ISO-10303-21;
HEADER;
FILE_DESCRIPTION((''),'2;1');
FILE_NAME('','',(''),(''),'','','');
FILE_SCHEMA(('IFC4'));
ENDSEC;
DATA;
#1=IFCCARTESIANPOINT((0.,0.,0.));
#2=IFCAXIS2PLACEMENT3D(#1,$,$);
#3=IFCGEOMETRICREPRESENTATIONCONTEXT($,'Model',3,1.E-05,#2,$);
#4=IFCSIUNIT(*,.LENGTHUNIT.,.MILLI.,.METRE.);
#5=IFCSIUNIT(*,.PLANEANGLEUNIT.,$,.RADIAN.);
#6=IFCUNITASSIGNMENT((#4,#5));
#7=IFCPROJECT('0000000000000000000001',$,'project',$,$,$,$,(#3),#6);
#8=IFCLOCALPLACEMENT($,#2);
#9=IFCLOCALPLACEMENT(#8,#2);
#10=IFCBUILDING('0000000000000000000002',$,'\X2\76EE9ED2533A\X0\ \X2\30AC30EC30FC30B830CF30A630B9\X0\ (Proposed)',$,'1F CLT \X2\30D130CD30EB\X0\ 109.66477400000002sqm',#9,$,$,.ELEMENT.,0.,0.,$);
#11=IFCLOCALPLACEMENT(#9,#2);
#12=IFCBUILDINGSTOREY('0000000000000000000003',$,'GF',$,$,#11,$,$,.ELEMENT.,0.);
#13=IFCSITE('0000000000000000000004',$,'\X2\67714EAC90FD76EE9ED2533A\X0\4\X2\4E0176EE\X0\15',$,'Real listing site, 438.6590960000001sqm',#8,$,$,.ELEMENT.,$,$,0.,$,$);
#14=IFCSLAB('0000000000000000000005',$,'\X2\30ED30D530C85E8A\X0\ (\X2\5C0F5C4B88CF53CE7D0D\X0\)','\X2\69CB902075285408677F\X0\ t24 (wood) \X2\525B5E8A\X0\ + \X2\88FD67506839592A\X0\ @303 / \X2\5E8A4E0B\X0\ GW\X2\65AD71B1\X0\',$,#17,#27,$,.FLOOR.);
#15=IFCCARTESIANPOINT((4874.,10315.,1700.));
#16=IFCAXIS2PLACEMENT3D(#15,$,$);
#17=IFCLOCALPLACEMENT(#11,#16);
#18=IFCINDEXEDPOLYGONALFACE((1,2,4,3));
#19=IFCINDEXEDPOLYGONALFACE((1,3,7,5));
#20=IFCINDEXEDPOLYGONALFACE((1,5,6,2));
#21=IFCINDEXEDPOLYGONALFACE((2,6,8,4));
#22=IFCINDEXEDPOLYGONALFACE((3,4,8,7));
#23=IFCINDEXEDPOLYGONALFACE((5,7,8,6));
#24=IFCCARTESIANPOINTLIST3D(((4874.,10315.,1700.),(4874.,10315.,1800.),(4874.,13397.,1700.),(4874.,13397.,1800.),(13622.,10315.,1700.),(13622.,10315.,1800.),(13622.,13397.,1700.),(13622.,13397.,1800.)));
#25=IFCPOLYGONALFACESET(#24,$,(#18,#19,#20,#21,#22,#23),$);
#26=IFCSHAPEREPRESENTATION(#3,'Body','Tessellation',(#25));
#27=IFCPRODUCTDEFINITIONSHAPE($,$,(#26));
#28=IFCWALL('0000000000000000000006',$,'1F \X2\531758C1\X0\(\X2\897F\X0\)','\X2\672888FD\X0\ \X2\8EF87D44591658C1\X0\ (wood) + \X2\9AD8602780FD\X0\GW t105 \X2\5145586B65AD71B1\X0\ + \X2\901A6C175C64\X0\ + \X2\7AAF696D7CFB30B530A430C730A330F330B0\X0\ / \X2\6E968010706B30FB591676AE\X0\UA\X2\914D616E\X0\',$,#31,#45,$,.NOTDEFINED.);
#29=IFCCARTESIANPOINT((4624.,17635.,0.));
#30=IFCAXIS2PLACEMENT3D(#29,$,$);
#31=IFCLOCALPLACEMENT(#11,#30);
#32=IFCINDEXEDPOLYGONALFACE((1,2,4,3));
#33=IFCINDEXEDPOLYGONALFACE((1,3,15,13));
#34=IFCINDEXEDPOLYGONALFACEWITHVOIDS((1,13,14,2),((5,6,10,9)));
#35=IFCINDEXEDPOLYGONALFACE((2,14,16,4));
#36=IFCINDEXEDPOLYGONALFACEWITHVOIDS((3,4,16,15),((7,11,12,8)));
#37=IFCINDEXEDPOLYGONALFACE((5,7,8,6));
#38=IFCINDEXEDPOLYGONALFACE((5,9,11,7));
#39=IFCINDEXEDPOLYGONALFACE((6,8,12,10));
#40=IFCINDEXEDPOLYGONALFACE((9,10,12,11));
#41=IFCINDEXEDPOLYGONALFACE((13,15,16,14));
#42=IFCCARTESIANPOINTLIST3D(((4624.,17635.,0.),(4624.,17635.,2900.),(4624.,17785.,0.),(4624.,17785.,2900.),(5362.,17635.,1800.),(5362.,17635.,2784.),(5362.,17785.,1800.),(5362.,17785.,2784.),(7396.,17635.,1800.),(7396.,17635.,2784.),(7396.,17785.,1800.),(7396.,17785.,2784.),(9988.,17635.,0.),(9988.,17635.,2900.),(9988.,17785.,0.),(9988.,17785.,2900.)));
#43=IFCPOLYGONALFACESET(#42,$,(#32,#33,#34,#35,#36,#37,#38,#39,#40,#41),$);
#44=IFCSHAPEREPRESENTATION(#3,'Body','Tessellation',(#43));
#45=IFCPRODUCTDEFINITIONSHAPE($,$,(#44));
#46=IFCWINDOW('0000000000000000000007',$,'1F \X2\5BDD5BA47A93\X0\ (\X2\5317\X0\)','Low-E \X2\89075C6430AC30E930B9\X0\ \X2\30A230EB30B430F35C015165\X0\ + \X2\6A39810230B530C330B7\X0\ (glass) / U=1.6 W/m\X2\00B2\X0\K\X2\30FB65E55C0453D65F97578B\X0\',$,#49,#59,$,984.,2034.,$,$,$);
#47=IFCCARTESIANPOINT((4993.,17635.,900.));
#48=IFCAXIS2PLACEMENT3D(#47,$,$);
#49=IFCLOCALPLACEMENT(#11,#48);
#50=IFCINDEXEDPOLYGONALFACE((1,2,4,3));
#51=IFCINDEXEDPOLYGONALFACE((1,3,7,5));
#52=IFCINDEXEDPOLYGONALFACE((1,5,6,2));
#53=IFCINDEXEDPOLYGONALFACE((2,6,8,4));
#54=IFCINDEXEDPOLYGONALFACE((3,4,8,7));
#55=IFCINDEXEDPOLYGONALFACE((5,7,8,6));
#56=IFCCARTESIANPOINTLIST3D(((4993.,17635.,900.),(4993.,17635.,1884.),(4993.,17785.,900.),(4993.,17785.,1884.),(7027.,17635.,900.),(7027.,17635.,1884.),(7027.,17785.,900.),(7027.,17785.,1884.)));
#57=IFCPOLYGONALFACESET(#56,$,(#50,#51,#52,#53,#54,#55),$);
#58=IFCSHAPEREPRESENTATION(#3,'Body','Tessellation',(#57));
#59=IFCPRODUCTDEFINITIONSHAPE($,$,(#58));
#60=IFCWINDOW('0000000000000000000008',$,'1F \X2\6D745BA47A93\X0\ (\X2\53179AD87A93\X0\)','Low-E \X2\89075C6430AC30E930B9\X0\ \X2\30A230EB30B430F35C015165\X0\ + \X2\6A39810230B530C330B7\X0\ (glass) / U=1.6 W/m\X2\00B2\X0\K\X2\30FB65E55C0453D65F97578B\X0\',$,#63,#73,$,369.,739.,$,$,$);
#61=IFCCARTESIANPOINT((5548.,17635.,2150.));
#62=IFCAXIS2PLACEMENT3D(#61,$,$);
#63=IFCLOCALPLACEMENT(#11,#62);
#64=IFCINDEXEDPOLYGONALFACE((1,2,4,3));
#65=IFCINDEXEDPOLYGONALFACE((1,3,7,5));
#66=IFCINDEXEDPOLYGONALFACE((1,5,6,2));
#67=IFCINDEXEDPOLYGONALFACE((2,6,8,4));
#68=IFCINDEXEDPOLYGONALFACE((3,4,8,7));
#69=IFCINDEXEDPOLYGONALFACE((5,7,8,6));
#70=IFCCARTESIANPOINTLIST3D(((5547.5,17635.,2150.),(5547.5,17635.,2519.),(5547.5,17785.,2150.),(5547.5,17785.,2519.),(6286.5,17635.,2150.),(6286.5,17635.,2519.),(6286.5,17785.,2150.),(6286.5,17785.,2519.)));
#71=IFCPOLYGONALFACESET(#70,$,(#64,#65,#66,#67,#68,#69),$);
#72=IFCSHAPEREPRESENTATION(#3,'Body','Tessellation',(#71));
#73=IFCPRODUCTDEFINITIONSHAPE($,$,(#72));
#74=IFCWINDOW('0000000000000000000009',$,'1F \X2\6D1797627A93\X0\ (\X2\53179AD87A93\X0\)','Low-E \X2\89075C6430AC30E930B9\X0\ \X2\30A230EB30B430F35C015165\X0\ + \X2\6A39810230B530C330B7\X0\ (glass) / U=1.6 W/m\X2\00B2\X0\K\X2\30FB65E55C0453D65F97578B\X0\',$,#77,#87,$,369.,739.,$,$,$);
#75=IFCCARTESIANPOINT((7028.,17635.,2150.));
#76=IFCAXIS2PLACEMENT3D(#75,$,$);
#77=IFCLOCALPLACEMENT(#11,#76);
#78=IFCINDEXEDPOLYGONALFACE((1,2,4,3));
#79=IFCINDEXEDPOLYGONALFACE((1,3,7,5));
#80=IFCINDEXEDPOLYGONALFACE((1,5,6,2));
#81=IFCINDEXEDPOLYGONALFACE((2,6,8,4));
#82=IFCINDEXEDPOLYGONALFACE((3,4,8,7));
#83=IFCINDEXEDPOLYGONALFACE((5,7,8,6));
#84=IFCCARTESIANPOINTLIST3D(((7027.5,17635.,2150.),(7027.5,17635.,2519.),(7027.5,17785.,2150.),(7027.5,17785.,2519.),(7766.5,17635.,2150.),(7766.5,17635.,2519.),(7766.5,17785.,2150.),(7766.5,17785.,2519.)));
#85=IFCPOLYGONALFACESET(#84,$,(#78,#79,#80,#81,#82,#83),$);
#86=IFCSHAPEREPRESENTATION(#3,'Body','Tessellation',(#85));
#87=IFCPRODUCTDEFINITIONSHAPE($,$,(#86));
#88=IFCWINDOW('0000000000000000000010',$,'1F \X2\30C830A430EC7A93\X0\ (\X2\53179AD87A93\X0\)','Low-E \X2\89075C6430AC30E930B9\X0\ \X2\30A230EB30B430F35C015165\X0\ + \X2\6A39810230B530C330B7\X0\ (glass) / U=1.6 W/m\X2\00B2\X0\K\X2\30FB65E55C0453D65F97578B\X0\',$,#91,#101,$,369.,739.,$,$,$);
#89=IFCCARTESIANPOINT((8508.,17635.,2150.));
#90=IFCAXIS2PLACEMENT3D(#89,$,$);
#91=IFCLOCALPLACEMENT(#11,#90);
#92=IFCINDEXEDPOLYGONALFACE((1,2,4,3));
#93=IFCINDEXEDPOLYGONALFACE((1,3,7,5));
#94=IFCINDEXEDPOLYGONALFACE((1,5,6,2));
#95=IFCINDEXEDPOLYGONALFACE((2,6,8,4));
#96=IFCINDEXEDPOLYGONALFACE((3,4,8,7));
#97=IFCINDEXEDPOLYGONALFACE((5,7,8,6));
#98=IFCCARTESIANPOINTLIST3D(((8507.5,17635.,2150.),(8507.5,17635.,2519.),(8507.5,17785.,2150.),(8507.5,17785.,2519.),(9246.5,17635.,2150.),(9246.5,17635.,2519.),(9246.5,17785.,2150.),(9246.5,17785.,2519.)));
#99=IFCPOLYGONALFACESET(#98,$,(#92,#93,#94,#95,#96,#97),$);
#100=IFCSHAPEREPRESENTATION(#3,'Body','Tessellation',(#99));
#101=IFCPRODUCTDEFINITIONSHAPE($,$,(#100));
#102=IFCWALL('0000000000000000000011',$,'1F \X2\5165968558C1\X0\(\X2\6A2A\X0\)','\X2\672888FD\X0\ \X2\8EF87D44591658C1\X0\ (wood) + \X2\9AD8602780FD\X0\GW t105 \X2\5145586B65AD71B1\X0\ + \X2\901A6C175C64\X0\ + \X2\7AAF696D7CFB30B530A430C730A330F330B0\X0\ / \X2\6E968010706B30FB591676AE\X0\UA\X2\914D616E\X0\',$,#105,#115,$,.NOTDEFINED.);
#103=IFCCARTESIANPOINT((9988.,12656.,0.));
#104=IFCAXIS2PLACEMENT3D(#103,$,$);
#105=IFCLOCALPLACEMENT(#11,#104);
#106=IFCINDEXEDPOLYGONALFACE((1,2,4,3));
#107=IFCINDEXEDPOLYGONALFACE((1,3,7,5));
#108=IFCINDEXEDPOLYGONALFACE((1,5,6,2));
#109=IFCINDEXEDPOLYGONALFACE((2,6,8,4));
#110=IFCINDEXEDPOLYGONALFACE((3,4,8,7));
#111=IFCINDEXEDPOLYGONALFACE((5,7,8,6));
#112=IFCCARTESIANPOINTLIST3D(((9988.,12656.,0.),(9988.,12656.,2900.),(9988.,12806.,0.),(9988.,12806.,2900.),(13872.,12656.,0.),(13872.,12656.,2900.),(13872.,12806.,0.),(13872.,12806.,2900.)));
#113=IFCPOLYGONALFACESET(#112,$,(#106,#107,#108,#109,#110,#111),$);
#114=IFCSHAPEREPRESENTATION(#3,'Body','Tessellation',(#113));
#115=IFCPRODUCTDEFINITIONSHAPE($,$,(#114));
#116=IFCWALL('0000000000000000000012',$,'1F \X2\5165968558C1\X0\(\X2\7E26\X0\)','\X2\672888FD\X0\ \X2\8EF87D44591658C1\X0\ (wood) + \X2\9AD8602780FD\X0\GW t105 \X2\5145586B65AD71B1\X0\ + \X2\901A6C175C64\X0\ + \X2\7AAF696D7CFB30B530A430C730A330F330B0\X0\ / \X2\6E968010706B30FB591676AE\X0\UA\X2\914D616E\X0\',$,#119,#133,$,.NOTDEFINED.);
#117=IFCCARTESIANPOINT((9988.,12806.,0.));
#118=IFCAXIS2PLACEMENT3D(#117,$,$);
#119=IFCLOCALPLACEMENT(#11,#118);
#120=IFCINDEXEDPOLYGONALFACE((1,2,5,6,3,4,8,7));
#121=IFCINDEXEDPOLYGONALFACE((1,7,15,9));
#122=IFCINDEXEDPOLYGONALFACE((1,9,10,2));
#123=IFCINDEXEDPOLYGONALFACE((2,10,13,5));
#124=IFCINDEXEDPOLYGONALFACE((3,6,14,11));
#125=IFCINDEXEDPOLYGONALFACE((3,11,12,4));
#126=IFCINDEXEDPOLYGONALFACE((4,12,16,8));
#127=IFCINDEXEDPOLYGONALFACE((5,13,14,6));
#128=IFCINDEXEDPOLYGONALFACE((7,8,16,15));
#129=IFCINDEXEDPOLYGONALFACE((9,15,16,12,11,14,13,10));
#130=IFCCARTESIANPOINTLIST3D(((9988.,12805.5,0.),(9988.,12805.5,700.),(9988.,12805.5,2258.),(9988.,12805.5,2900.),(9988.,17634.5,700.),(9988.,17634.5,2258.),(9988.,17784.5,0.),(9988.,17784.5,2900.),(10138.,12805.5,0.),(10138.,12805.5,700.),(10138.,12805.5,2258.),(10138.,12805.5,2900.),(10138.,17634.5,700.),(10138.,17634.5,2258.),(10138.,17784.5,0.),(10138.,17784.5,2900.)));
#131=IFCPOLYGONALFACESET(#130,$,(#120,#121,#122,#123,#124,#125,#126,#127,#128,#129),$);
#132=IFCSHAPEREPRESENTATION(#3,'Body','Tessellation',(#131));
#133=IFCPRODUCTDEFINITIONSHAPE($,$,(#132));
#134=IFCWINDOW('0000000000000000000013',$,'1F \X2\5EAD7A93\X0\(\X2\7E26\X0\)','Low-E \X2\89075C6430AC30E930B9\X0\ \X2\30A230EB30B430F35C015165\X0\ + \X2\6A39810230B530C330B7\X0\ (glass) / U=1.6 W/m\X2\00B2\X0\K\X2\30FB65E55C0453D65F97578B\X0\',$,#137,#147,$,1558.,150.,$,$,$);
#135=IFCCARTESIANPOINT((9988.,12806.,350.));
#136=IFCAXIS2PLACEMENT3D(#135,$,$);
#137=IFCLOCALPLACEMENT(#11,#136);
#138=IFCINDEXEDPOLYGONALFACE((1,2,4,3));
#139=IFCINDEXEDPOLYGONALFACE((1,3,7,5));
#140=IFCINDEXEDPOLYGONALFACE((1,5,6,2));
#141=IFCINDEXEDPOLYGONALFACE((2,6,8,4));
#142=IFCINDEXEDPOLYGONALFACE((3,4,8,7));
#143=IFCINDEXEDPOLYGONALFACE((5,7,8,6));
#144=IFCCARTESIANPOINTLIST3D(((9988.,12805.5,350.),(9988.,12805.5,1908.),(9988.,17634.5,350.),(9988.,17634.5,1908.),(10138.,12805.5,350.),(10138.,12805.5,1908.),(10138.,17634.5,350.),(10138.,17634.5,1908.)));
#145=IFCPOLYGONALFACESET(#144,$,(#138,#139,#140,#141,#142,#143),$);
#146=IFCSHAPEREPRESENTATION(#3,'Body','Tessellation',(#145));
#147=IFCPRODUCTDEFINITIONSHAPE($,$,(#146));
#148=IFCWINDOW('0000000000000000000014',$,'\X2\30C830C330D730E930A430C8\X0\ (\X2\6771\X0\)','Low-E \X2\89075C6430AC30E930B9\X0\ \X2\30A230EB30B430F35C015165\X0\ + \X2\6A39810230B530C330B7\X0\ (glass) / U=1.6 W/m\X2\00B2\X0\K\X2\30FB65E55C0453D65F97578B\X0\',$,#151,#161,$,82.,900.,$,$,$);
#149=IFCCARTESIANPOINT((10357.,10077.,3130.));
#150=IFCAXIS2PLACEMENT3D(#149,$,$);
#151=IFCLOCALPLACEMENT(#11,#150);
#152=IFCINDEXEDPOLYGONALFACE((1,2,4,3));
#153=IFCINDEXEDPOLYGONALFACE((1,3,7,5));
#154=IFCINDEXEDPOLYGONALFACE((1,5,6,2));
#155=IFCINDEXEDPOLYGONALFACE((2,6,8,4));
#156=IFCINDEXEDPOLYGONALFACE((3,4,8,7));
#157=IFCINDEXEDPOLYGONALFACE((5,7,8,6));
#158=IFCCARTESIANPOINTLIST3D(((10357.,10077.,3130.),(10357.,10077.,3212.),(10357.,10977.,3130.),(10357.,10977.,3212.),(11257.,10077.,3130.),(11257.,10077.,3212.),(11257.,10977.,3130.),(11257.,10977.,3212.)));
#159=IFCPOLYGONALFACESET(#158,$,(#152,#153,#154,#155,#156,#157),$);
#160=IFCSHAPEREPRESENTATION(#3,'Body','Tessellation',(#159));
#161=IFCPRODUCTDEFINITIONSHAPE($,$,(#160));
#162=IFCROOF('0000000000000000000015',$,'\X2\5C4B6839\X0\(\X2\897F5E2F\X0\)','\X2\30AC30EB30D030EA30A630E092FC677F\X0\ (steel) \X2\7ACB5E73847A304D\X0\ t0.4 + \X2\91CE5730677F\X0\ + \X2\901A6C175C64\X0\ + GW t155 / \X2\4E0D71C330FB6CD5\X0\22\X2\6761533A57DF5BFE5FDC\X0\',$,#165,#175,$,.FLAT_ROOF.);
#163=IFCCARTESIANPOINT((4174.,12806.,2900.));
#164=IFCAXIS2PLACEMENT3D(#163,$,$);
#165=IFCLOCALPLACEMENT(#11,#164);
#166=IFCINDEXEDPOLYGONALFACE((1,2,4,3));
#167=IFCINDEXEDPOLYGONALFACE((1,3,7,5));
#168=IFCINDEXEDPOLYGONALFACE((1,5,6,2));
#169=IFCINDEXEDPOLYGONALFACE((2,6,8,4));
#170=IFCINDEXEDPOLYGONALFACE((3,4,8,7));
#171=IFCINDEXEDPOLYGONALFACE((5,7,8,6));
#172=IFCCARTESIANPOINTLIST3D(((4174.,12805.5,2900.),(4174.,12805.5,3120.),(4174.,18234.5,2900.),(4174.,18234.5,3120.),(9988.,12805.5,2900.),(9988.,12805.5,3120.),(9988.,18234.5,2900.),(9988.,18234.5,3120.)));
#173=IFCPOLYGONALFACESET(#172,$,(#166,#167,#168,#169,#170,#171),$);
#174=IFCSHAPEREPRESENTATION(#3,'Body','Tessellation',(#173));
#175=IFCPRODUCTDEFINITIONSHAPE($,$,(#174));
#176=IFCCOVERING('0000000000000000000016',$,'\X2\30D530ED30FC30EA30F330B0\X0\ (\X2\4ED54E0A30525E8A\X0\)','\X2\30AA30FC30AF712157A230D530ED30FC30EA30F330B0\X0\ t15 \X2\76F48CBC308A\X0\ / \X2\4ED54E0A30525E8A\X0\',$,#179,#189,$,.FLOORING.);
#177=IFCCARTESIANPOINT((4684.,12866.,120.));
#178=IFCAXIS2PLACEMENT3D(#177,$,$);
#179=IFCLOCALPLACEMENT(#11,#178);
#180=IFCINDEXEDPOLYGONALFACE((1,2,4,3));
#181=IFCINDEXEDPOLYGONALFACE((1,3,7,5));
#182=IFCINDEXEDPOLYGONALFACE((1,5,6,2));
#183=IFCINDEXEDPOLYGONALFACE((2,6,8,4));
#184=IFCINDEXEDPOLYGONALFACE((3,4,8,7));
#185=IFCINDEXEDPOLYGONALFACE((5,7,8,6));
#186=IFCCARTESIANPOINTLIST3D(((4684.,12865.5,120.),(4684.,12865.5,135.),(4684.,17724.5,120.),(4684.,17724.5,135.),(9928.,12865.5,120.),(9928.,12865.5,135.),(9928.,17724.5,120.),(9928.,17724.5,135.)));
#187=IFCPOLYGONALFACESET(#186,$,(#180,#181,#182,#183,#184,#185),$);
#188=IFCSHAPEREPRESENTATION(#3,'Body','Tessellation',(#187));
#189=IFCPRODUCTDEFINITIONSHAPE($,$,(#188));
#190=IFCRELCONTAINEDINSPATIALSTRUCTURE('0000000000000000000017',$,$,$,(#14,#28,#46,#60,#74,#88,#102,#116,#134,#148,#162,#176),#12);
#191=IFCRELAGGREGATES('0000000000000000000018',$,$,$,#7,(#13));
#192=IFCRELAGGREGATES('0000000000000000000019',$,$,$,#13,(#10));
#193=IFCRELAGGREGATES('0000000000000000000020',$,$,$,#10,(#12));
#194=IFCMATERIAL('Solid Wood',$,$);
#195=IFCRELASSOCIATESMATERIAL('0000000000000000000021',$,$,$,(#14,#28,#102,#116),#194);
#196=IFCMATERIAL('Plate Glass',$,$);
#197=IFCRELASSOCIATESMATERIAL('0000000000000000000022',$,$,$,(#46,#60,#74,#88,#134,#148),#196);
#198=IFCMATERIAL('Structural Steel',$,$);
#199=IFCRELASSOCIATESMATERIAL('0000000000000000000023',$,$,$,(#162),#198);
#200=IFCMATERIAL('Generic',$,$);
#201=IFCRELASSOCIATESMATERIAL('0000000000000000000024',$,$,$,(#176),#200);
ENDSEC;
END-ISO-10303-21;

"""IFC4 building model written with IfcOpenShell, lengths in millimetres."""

from ifc_helpers import new_model, si_unit, frame, frame_2d, origin, place, context, project, spatial, rectangle, extrude, material, element, fill, save


model = new_model("IFC4")

# Units and contexts
model_context = context("Model", 3, precision=1e-05, world=origin())
ifc_project = project(units=[si_unit("LENGTHUNIT", "METRE", prefix="MILLI"), si_unit("PLANEANGLEUNIT", "RADIAN")], contexts=[model_context])

# Site, building, storey
site_placement = place(None, origin())
site = spatial("IfcSite", under=ifc_project, at=site_placement, Name="東京都目黒区4丁目15", ObjectType="Real listing site, 438.6590960000001sqm", CompositionType="ELEMENT", RefElevation=0.0)
building_placement = place(site_placement, origin())
building = spatial("IfcBuilding", under=site, at=building_placement, Name="目黒区 ガレージハウス (Proposed)", ObjectType="1F CLT パネル 109.66477400000002sqm", CompositionType="ELEMENT", ElevationOfRefHeight=0.0, ElevationOfTerrain=0.0)
storey_placement = place(building_placement, origin())
storey = spatial("IfcBuildingStorey", under=building, at=storey_placement, Name="GF", CompositionType="ELEMENT", Elevation=0.0)

# Slab
ifc_material_1 = material(Name="Solid Wood")
slab_1_placement = place(storey_placement, frame((4874.0, 10315.0, 1700.0)))
element("IfcSlab", 1, at=slab_1_placement, inside=storey, material=ifc_material_1, Name="ロフト床 (小屋裏収納)", Description="構造用合板 t24 (wood) 剛床 + 製材根太 @303 / 床下 GW断熱", PredefinedType="FLOOR", context=model_context, shape_type="SweptSolid", body=[
    extrude(rectangle(XDim=8748.0, YDim=3082.0, at=frame_2d((4374.0, 1541.0))), frame((4874.0, 10315.0, 1700.0)), (0.0, 0.0, 1.0), 100.0),
])

# Wall, openings, windows
wall_1_placement = place(storey_placement, frame((4624.0, 17635.0, 0.0)))
wall_1 = element("IfcWall", 2, at=wall_1_placement, inside=storey, material=ifc_material_1, Name="1F 北壁(西)", Description="木製 軸組外壁 (wood) + 高性能GW t105 充填断熱 + 通気層 + 窯業系サイディング / 準耐火・外皮UA配慮", PredefinedType="NOTDEFINED", context=model_context, shape_type="SweptSolid", body=[
    extrude(rectangle(XDim=5364.0, YDim=150.0, at=frame_2d((2682.0, 75.0))), frame((4624.0, 17635.0, 0.0)), (0.0, 0.0, 1.0), 2900.0),
])
opening_1_placement = place(storey_placement, frame((4993.0, 17635.0, 900.0)))
opening_1 = element("IfcOpeningElement", 3, at=opening_1_placement, cuts=wall_1, PredefinedType="NOTDEFINED", context=model_context, shape_type="SweptSolid", body=[
    extrude(rectangle(XDim=2034.0, YDim=150.0, at=frame_2d((1017.0, 75.0))), frame((4993.0, 17635.0, 900.0)), (0.0, 0.0, 1.0), 984.0),
])
opening_2_placement = place(storey_placement, frame((5548.0, 17635.0, 2150.0)))
opening_2 = element("IfcOpeningElement", 4, at=opening_2_placement, cuts=wall_1, PredefinedType="NOTDEFINED", context=model_context, shape_type="SweptSolid", body=[
    extrude(rectangle(XDim=739.0, YDim=150.0, at=frame_2d((369.0, 75.0))), frame((5548.0, 17635.0, 2150.0)), (0.0, 0.0, 1.0), 369.0),
])
opening_3_placement = place(storey_placement, frame((7028.0, 17635.0, 2150.0)))
opening_3 = element("IfcOpeningElement", 5, at=opening_3_placement, cuts=wall_1, PredefinedType="NOTDEFINED", context=model_context, shape_type="SweptSolid", body=[
    extrude(rectangle(XDim=739.0, YDim=150.0, at=frame_2d((369.0, 75.0))), frame((7028.0, 17635.0, 2150.0)), (0.0, 0.0, 1.0), 369.0),
])
opening_4_placement = place(storey_placement, frame((8508.0, 17635.0, 2150.0)))
opening_4 = element("IfcOpeningElement", 6, at=opening_4_placement, cuts=wall_1, PredefinedType="NOTDEFINED", context=model_context, shape_type="SweptSolid", body=[
    extrude(rectangle(XDim=739.0, YDim=150.0, at=frame_2d((369.0, 75.0))), frame((8508.0, 17635.0, 2150.0)), (0.0, 0.0, 1.0), 369.0),
])
ifc_material_2 = material(Name="Plate Glass")
window_1_placement = place(storey_placement, frame((4993.0, 17635.0, 900.0)))
window_1 = element("IfcWindow", 7, at=window_1_placement, inside=storey, material=ifc_material_2, Name="1F 寝室窓 (北)", Description="Low-E 複層ガラス アルゴン封入 + 樹脂サッシ (glass) / U=1.6 W/m²K・日射取得型", OverallHeight=984.0, OverallWidth=2034.0, context=model_context, shape_type="SweptSolid", body=[
    extrude(rectangle(XDim=2034.0, YDim=150.0, at=frame_2d((1017.0, 75.0))), frame((4993.0, 17635.0, 900.0)), (0.0, 0.0, 1.0), 984.0),
])
fill(opening_1, window_1)
window_2_placement = place(storey_placement, frame((5548.0, 17635.0, 2150.0)))
window_2 = element("IfcWindow", 8, at=window_2_placement, inside=storey, material=ifc_material_2, Name="1F 浴室窓 (北高窓)", Description="Low-E 複層ガラス アルゴン封入 + 樹脂サッシ (glass) / U=1.6 W/m²K・日射取得型", OverallHeight=369.0, OverallWidth=739.0, context=model_context, shape_type="SweptSolid", body=[
    extrude(rectangle(XDim=739.0, YDim=150.0, at=frame_2d((369.0, 75.0))), frame((5548.0, 17635.0, 2150.0)), (0.0, 0.0, 1.0), 369.0),
])
fill(opening_2, window_2)
window_3_placement = place(storey_placement, frame((7028.0, 17635.0, 2150.0)))
window_3 = element("IfcWindow", 9, at=window_3_placement, inside=storey, material=ifc_material_2, Name="1F 洗面窓 (北高窓)", Description="Low-E 複層ガラス アルゴン封入 + 樹脂サッシ (glass) / U=1.6 W/m²K・日射取得型", OverallHeight=369.0, OverallWidth=739.0, context=model_context, shape_type="SweptSolid", body=[
    extrude(rectangle(XDim=739.0, YDim=150.0, at=frame_2d((369.0, 75.0))), frame((7028.0, 17635.0, 2150.0)), (0.0, 0.0, 1.0), 369.0),
])
fill(opening_3, window_3)
window_4_placement = place(storey_placement, frame((8508.0, 17635.0, 2150.0)))
window_4 = element("IfcWindow", 10, at=window_4_placement, inside=storey, material=ifc_material_2, Name="1F トイレ窓 (北高窓)", Description="Low-E 複層ガラス アルゴン封入 + 樹脂サッシ (glass) / U=1.6 W/m²K・日射取得型", OverallHeight=369.0, OverallWidth=739.0, context=model_context, shape_type="SweptSolid", body=[
    extrude(rectangle(XDim=739.0, YDim=150.0, at=frame_2d((369.0, 75.0))), frame((8508.0, 17635.0, 2150.0)), (0.0, 0.0, 1.0), 369.0),
])
fill(opening_4, window_4)

# Wall
wall_2_placement = place(storey_placement, frame((9988.0, 12656.0, 0.0)))
element("IfcWall", 11, at=wall_2_placement, inside=storey, material=ifc_material_1, Name="1F 入隅壁(横)", Description="木製 軸組外壁 (wood) + 高性能GW t105 充填断熱 + 通気層 + 窯業系サイディング / 準耐火・外皮UA配慮", PredefinedType="NOTDEFINED", context=model_context, shape_type="SweptSolid", body=[
    extrude(rectangle(XDim=3884.0, YDim=150.0, at=frame_2d((1942.0, 75.0))), frame((9988.0, 12656.0, 0.0)), (0.0, 0.0, 1.0), 2900.0),
])

# Wall, opening, window
wall_3_placement = place(storey_placement, frame((9988.0, 12806.0, 0.0)))
wall_3 = element("IfcWall", 12, at=wall_3_placement, inside=storey, material=ifc_material_1, Name="1F 入隅壁(縦)", Description="木製 軸組外壁 (wood) + 高性能GW t105 充填断熱 + 通気層 + 窯業系サイディング / 準耐火・外皮UA配慮", PredefinedType="NOTDEFINED", context=model_context, shape_type="SweptSolid", body=[
    extrude(rectangle(XDim=150.0, YDim=4979.0, at=frame_2d((75.0, 2489.0))), frame((9988.0, 12806.0, 0.0)), (0.0, 0.0, 1.0), 2900.0),
])
opening_5_placement = place(storey_placement, frame((9988.0, 12806.0, 350.0)))
opening_5 = element("IfcOpeningElement", 13, at=opening_5_placement, cuts=wall_3, PredefinedType="NOTDEFINED", context=model_context, shape_type="SweptSolid", body=[
    extrude(rectangle(XDim=150.0, YDim=4829.0, at=frame_2d((75.0, 2414.0))), frame((9988.0, 12806.0, 350.0)), (0.0, 0.0, 1.0), 1558.0),
])
window_5_placement = place(storey_placement, frame((9988.0, 12806.0, 350.0)))
window_5 = element("IfcWindow", 14, at=window_5_placement, inside=storey, material=ifc_material_2, Name="1F 庭窓(縦)", Description="Low-E 複層ガラス アルゴン封入 + 樹脂サッシ (glass) / U=1.6 W/m²K・日射取得型", OverallHeight=1558.0, OverallWidth=150.0, context=model_context, shape_type="SweptSolid", body=[
    extrude(rectangle(XDim=150.0, YDim=4829.0, at=frame_2d((75.0, 2414.0))), frame((9988.0, 12806.0, 350.0)), (0.0, 0.0, 1.0), 1558.0),
])
fill(opening_5, window_5)

# Window
window_6_placement = place(storey_placement, frame((10357.0, 10077.0, 3130.0)))
element("IfcWindow", 15, at=window_6_placement, inside=storey, material=ifc_material_2, Name="トップライト (東)", Description="Low-E 複層ガラス アルゴン封入 + 樹脂サッシ (glass) / U=1.6 W/m²K・日射取得型", OverallHeight=82.0, OverallWidth=900.0, context=model_context, shape_type="SweptSolid", body=[
    extrude(rectangle(XDim=900.0, YDim=900.0, at=frame_2d((450.0, 450.0))), frame((10357.0, 10077.0, 3130.0)), (0.0, 0.0, 1.0), 82.0),
])

# Roof
ifc_material_3 = material(Name="Structural Steel")
roof_placement = place(storey_placement, frame((4174.0, 12806.0, 2900.0)))
element("IfcRoof", 16, at=roof_placement, inside=storey, material=ifc_material_3, Name="屋根(西帯)", Description="ガルバリウム鋼板 (steel) 立平葺き t0.4 + 野地板 + 通気層 + GW t155 / 不燃・法22条区域対応", PredefinedType="FLAT_ROOF", context=model_context, shape_type="SweptSolid", body=[
    extrude(rectangle(XDim=5814.0, YDim=5429.0, at=frame_2d((2907.0, 2714.0))), frame((4174.0, 12806.0, 2900.0)), (0.0, 0.0, 1.0), 220.0),
])

# Covering
ifc_material_4 = material(Name="Generic")
covering_placement = place(storey_placement, frame((4684.0, 12866.0, 120.0)))
element("IfcCovering", 17, at=covering_placement, inside=storey, material=ifc_material_4, Name="フローリング (仕上げ床)", Description="オーク無垢フローリング t15 直貼り / 仕上げ床", PredefinedType="FLOORING", context=model_context, shape_type="SweptSolid", body=[
    extrude(rectangle(XDim=5244.0, YDim=4859.0, at=frame_2d((2622.0, 2429.0))), frame((4684.0, 12866.0, 120.0)), (0.0, 0.0, 1.0), 15.0),
])

save(model, "model.ifc")
